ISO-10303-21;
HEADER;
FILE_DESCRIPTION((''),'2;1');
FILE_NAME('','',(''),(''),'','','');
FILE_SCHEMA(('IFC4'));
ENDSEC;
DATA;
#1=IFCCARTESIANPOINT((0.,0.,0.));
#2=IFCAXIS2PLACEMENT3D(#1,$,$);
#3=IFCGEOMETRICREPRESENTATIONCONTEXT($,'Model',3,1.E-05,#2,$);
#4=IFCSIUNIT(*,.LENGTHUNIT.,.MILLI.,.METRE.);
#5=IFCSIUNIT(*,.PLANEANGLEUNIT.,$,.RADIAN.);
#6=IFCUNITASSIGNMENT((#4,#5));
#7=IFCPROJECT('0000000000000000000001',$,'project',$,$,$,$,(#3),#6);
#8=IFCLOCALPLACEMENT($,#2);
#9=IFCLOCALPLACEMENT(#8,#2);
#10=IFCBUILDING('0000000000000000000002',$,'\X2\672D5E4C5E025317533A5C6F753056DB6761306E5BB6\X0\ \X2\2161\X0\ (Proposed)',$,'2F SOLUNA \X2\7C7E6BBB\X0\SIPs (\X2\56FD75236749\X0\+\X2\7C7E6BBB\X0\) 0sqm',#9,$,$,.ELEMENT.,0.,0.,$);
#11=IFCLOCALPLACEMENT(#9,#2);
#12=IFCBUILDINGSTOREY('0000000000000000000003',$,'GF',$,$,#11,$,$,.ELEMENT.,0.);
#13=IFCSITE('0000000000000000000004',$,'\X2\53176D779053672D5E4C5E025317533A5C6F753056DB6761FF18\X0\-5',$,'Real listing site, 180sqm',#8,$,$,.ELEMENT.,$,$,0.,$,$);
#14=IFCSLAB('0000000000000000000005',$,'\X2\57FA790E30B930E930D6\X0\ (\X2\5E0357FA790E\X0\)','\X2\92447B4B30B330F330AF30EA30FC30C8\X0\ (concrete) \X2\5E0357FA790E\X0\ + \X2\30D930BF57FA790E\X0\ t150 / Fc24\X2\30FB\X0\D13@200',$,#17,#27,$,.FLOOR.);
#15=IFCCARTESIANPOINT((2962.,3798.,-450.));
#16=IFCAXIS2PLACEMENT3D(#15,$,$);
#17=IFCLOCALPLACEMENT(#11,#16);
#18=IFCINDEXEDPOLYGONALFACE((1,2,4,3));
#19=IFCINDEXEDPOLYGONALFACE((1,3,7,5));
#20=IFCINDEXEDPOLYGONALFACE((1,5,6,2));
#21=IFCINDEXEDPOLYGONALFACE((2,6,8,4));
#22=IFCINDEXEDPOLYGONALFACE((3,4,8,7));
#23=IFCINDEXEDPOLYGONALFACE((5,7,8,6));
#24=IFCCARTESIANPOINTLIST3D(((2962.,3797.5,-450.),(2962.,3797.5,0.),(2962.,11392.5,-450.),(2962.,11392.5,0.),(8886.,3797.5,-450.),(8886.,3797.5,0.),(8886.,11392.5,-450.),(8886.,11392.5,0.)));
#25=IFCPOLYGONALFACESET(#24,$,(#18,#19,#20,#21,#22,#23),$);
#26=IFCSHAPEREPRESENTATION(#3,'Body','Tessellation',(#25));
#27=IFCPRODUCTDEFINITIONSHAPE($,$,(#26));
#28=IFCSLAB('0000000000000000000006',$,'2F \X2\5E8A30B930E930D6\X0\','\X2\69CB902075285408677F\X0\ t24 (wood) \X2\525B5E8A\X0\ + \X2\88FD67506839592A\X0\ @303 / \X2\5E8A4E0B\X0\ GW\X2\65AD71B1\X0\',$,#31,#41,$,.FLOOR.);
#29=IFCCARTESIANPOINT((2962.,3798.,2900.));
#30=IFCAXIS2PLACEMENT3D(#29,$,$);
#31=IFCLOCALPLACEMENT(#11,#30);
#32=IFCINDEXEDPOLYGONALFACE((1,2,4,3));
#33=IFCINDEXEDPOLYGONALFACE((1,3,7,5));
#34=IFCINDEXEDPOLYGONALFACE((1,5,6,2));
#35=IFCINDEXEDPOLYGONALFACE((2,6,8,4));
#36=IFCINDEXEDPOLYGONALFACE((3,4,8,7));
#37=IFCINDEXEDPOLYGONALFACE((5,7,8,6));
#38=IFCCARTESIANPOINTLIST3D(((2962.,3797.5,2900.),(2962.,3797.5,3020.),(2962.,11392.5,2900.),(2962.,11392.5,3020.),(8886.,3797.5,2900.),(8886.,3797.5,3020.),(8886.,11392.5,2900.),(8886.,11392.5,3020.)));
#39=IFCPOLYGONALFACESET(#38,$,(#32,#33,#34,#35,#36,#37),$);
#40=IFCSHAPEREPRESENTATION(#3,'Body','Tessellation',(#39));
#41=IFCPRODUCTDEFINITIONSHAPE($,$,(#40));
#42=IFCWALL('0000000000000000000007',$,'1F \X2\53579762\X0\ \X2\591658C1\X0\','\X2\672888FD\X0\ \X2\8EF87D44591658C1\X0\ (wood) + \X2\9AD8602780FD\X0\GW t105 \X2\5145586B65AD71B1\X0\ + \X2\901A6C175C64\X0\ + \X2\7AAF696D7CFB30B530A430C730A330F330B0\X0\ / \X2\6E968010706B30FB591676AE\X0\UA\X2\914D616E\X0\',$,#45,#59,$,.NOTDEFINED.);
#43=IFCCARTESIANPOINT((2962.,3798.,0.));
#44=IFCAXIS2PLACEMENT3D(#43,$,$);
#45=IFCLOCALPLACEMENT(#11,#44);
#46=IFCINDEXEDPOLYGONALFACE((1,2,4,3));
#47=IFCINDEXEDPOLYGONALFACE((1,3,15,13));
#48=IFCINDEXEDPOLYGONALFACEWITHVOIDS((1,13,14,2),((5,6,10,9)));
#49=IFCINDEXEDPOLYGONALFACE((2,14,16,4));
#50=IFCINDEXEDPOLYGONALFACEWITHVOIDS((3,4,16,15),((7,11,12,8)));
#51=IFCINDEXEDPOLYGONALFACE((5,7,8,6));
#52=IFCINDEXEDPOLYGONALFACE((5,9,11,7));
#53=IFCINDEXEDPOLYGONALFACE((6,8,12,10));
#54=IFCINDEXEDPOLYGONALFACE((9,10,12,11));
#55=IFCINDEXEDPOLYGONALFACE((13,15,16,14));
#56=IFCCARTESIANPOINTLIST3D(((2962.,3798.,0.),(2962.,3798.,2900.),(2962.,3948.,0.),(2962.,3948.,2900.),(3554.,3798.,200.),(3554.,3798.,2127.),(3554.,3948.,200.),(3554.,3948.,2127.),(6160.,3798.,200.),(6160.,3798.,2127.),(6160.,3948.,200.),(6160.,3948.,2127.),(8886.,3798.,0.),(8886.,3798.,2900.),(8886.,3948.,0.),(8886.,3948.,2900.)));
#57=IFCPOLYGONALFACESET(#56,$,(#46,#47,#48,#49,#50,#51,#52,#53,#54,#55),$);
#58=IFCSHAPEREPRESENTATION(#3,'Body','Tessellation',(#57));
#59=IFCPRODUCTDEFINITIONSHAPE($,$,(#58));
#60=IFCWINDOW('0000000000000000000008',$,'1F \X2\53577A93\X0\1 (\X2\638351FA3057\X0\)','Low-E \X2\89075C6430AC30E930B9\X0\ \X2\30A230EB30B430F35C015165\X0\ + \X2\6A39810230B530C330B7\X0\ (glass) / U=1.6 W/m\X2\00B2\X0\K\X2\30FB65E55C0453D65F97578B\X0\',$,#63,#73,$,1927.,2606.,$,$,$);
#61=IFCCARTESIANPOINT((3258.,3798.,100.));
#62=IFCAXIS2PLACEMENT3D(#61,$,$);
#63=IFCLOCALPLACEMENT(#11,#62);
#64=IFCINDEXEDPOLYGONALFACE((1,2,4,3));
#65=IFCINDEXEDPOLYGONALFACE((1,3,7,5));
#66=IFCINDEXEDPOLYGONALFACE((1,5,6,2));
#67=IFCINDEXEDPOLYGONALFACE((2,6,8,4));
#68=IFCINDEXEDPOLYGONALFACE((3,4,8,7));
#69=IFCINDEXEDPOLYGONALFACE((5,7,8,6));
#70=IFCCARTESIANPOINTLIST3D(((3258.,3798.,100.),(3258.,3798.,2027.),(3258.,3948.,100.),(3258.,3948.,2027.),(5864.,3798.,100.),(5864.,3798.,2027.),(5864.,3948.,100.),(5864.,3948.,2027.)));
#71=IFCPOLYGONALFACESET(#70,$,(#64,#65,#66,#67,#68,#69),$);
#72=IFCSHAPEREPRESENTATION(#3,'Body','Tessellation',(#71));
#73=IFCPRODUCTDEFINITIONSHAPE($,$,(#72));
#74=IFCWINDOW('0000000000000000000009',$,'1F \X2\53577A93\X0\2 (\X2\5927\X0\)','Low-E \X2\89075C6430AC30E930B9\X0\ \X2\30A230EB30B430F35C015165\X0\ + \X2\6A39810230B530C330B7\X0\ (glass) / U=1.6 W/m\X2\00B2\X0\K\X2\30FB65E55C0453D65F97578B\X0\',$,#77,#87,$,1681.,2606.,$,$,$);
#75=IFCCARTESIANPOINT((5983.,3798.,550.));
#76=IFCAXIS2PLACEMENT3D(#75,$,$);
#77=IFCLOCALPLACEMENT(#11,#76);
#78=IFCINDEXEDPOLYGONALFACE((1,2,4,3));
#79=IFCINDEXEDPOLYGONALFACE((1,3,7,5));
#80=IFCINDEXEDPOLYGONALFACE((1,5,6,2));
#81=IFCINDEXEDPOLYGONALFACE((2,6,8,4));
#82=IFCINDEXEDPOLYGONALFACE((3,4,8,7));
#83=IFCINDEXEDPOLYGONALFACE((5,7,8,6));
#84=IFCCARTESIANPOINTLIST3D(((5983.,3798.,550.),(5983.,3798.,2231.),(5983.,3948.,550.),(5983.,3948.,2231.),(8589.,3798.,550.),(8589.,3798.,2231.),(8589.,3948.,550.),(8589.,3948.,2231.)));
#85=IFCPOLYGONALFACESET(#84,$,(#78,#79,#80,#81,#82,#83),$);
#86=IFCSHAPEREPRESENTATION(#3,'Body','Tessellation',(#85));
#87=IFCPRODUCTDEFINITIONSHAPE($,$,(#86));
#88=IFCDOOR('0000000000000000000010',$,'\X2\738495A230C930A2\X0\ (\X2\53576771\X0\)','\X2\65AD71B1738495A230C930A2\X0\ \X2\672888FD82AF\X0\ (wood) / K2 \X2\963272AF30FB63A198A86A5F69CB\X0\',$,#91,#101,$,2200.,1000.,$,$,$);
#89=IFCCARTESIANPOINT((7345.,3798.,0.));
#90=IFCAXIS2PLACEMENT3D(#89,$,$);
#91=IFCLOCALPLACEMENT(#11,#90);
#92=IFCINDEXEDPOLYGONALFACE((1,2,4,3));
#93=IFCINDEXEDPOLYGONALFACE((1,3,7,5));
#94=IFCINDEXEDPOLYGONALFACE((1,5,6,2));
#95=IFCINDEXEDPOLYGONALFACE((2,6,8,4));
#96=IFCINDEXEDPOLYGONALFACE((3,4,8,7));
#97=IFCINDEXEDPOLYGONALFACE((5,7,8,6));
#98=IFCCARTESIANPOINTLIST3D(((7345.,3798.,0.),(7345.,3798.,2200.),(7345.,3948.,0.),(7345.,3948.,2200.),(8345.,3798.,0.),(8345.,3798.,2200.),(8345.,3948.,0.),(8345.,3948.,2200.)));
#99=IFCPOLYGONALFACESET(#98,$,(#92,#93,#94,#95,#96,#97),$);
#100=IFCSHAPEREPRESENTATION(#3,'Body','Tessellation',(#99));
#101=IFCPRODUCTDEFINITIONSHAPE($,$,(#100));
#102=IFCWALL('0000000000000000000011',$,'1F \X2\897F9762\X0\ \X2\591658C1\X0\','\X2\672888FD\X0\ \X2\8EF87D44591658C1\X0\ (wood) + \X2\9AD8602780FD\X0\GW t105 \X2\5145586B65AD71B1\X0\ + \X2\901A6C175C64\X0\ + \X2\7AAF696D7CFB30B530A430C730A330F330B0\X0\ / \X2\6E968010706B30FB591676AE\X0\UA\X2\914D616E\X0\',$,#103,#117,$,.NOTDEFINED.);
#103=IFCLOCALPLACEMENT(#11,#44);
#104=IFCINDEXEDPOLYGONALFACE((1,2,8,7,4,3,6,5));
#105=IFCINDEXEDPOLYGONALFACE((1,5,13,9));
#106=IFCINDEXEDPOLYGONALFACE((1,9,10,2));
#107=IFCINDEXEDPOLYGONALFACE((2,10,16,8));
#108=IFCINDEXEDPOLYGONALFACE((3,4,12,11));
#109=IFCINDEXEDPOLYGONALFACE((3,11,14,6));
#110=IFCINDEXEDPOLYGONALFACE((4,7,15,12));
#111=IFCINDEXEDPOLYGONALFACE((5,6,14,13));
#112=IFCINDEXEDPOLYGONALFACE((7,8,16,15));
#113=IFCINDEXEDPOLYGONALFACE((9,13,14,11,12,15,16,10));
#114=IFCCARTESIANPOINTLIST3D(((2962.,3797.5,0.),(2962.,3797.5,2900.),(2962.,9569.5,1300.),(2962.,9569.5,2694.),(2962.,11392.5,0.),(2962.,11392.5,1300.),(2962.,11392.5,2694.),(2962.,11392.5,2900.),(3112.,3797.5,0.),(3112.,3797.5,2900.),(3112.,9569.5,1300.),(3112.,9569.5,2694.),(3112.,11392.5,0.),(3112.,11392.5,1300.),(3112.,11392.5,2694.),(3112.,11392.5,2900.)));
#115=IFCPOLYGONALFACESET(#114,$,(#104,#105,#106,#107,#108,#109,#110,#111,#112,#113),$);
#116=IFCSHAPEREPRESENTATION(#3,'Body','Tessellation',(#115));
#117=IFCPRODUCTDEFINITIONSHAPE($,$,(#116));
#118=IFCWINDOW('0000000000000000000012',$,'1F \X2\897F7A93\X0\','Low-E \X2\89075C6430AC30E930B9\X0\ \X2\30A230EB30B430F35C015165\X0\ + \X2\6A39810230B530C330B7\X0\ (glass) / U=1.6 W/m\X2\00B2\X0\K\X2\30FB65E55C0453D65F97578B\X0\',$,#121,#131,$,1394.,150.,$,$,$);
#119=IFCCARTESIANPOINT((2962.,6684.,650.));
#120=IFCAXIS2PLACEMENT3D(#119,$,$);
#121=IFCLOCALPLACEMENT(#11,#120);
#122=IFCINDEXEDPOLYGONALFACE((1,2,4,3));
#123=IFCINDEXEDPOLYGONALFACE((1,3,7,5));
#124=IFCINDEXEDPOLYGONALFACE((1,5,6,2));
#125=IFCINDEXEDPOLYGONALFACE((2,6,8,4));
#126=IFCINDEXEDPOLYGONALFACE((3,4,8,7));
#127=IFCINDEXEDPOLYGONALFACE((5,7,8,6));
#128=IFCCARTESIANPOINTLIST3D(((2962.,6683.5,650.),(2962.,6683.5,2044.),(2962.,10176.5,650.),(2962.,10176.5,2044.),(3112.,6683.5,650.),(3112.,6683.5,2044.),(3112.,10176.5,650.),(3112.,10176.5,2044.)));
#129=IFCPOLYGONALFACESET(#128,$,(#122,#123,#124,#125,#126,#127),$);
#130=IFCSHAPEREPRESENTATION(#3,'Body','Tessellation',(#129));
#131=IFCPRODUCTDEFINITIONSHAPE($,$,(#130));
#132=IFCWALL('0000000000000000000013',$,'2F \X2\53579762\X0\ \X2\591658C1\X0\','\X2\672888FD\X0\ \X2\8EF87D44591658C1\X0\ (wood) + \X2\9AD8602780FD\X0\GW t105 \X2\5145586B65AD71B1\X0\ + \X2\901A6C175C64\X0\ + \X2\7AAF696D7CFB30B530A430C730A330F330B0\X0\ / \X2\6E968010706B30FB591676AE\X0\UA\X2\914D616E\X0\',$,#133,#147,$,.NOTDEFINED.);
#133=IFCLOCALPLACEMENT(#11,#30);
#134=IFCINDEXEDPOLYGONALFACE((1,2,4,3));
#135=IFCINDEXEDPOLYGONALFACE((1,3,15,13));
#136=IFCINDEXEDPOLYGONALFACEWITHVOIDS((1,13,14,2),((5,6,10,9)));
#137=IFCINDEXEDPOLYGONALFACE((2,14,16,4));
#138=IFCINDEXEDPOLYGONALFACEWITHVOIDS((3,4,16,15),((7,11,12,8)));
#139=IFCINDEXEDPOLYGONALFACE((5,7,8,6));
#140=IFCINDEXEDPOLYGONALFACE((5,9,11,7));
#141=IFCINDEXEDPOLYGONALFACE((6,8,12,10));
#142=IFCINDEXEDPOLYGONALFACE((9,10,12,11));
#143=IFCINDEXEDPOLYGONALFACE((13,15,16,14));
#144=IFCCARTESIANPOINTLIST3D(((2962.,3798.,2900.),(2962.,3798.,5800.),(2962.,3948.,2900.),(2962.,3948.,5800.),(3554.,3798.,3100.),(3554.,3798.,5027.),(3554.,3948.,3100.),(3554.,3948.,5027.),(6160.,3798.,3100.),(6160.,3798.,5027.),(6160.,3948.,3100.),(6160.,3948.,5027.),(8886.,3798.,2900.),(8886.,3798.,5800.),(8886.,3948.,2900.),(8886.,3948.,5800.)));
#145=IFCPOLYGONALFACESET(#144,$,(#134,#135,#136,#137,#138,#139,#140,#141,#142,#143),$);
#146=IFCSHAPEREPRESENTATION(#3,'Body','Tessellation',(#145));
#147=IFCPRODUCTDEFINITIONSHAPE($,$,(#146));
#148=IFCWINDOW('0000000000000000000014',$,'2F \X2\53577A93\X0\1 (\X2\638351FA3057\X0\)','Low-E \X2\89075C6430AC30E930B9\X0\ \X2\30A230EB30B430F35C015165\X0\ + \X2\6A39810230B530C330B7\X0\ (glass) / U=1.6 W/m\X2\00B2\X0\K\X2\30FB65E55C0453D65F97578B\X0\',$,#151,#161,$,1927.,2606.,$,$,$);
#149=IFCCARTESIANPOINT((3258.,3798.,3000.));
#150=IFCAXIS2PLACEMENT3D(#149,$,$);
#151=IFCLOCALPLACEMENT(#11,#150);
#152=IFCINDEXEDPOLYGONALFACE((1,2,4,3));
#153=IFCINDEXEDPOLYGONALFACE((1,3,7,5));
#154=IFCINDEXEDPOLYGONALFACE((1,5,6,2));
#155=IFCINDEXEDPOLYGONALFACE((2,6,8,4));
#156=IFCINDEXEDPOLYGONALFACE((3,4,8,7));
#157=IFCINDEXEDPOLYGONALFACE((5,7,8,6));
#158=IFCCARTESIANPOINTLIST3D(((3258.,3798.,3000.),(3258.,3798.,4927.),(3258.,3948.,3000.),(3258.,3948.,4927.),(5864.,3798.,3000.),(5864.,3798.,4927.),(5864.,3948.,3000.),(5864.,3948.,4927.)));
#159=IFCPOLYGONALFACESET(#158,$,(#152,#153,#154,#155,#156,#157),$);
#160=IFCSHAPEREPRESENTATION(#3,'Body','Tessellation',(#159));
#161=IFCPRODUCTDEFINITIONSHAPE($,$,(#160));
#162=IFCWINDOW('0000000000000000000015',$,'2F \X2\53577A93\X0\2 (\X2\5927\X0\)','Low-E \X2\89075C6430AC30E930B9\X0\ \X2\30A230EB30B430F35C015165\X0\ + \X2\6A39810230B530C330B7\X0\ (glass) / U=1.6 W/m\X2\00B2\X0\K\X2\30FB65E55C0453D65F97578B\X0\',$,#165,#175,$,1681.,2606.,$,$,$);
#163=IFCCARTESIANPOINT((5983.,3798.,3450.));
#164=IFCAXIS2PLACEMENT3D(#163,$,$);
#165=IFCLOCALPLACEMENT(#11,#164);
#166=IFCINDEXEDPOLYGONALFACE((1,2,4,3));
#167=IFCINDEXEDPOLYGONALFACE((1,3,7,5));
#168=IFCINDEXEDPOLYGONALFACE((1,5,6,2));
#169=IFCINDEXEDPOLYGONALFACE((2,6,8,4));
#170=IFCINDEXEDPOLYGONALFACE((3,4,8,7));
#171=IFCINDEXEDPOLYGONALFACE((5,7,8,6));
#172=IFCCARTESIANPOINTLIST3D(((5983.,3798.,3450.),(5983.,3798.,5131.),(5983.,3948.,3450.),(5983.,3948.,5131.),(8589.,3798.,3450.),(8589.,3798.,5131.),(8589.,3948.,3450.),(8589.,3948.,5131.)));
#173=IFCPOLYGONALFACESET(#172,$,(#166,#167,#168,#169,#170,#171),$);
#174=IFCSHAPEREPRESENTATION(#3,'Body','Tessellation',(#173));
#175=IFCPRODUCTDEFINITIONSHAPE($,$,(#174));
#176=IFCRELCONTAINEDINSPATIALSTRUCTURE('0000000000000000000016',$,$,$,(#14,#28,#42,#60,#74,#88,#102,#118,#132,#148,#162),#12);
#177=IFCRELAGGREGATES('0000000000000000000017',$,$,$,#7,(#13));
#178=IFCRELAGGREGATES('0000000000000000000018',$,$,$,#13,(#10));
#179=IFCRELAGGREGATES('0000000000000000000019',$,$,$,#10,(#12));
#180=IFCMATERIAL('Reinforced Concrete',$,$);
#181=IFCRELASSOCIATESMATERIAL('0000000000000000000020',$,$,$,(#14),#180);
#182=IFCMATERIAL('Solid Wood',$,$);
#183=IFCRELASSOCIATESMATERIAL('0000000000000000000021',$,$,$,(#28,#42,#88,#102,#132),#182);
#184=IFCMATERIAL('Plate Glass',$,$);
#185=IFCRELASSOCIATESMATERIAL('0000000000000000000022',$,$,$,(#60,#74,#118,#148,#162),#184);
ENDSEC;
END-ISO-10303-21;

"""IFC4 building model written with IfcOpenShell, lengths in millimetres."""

from ifc_helpers import new_model, si_unit, frame, frame_2d, origin, place, context, project, spatial, rectangle, extrude, material, element, fill, save


model = new_model("IFC4")

# Units and contexts
model_context = context("Model", 3, precision=1e-05, world=origin())
ifc_project = project(units=[si_unit("LENGTHUNIT", "METRE", prefix="MILLI"), si_unit("PLANEANGLEUNIT", "RADIAN")], contexts=[model_context])

# Site, building, storey
site_placement = place(None, origin())
site = spatial("IfcSite", under=ifc_project, at=site_placement, Name="北海道札幌市北区屯田四条８-5", ObjectType="Real listing site, 180sqm", CompositionType="ELEMENT", RefElevation=0.0)
building_placement = place(site_placement, origin())
building = spatial("IfcBuilding", under=site, at=building_placement, Name="札幌市北区屯田四条の家 Ⅱ (Proposed)", ObjectType="2F SOLUNA 籾殻SIPs (国産杉+籾殻) 0sqm", CompositionType="ELEMENT", ElevationOfRefHeight=0.0, ElevationOfTerrain=0.0)
storey_placement = place(building_placement, origin())
storey = spatial("IfcBuildingStorey", under=building, at=storey_placement, Name="GF", CompositionType="ELEMENT", Elevation=0.0)

# Slabs
ifc_material_1 = material(Name="Reinforced Concrete")
slab_1_placement = place(storey_placement, frame((2962.0, 3798.0, -450.0)))
element("IfcSlab", 1, at=slab_1_placement, inside=storey, material=ifc_material_1, Name="基礎スラブ (布基礎)", Description="鉄筋コンクリート (concrete) 布基礎 + ベタ基礎 t150 / Fc24・D13@200", PredefinedType="FLOOR", context=model_context, shape_type="SweptSolid", body=[
    extrude(rectangle(XDim=5924.0, YDim=7595.0, at=frame_2d((2962.0, 3797.0))), frame((2962.0, 3798.0, -450.0)), (0.0, 0.0, 1.0), 450.0),
])
ifc_material_2 = material(Name="Solid Wood")
slab_2_placement = place(storey_placement, frame((2962.0, 3798.0, 2900.0)))
element("IfcSlab", 2, at=slab_2_placement, inside=storey, material=ifc_material_2, Name="2F 床スラブ", Description="構造用合板 t24 (wood) 剛床 + 製材根太 @303 / 床下 GW断熱", PredefinedType="FLOOR", context=model_context, shape_type="SweptSolid", body=[
    extrude(rectangle(XDim=5924.0, YDim=7595.0, at=frame_2d((2962.0, 3797.0))), frame((2962.0, 3798.0, 2900.0)), (0.0, 0.0, 1.0), 120.0),
])

# Wall, openings, windows, door
wall_1_placement = place(storey_placement, frame((2962.0, 3798.0, 0.0)))
wall_1 = element("IfcWall", 3, at=wall_1_placement, inside=storey, material=ifc_material_2, Name="1F 南面 外壁", Description="木製 軸組外壁 (wood) + 高性能GW t105 充填断熱 + 通気層 + 窯業系サイディング / 準耐火・外皮UA配慮", PredefinedType="NOTDEFINED", context=model_context, shape_type="SweptSolid", body=[
    extrude(rectangle(XDim=5924.0, YDim=150.0, at=frame_2d((2962.0, 75.0))), frame((2962.0, 3798.0, 0.0)), (0.0, 0.0, 1.0), 2900.0),
])
opening_1_placement = place(storey_placement, frame((3258.0, 3798.0, 100.0)))
opening_1 = element("IfcOpeningElement", 4, at=opening_1_placement, cuts=wall_1, PredefinedType="NOTDEFINED", context=model_context, shape_type="SweptSolid", body=[
    extrude(rectangle(XDim=2606.0, YDim=150.0, at=frame_2d((1303.0, 75.0))), frame((3258.0, 3798.0, 100.0)), (0.0, 0.0, 1.0), 1927.0),
])
opening_2_placement = place(storey_placement, frame((5983.0, 3798.0, 550.0)))
opening_2 = element("IfcOpeningElement", 5, at=opening_2_placement, cuts=wall_1, PredefinedType="NOTDEFINED", context=model_context, shape_type="SweptSolid", body=[
    extrude(rectangle(XDim=2606.0, YDim=150.0, at=frame_2d((1303.0, 75.0))), frame((5983.0, 3798.0, 550.0)), (0.0, 0.0, 1.0), 1681.0),
])
opening_3_placement = place(storey_placement, frame((7345.0, 3798.0, 0.0)))
opening_3 = element("IfcOpeningElement", 6, at=opening_3_placement, cuts=wall_1, PredefinedType="NOTDEFINED", context=model_context, shape_type="SweptSolid", body=[
    extrude(rectangle(XDim=1000.0, YDim=150.0, at=frame_2d((500.0, 75.0))), frame((7345.0, 3798.0, 0.0)), (0.0, 0.0, 1.0), 2200.0),
])
ifc_material_3 = material(Name="Plate Glass")
window_1_placement = place(storey_placement, frame((3258.0, 3798.0, 100.0)))
window_1 = element("IfcWindow", 7, at=window_1_placement, inside=storey, material=ifc_material_3, Name="1F 南窓1 (掃出し)", Description="Low-E 複層ガラス アルゴン封入 + 樹脂サッシ (glass) / U=1.6 W/m²K・日射取得型", OverallHeight=1927.0, OverallWidth=2606.0, context=model_context, shape_type="SweptSolid", body=[
    extrude(rectangle(XDim=2606.0, YDim=150.0, at=frame_2d((1303.0, 75.0))), frame((3258.0, 3798.0, 100.0)), (0.0, 0.0, 1.0), 1927.0),
])
fill(opening_1, window_1)
window_2_placement = place(storey_placement, frame((5983.0, 3798.0, 550.0)))
window_2 = element("IfcWindow", 8, at=window_2_placement, inside=storey, material=ifc_material_3, Name="1F 南窓2 (大)", Description="Low-E 複層ガラス アルゴン封入 + 樹脂サッシ (glass) / U=1.6 W/m²K・日射取得型", OverallHeight=1681.0, OverallWidth=2606.0, context=model_context, shape_type="SweptSolid", body=[
    extrude(rectangle(XDim=2606.0, YDim=150.0, at=frame_2d((1303.0, 75.0))), frame((5983.0, 3798.0, 550.0)), (0.0, 0.0, 1.0), 1681.0),
])
fill(opening_2, window_2)
door_placement = place(storey_placement, frame((7345.0, 3798.0, 0.0)))
door = element("IfcDoor", 9, at=door_placement, inside=storey, material=ifc_material_2, Name="玄関ドア (南東)", Description="断熱玄関ドア 木製芯 (wood) / K2 防犯・採風機構", OverallHeight=2200.0, OverallWidth=1000.0, context=model_context, shape_type="SweptSolid", body=[
    extrude(rectangle(XDim=1000.0, YDim=150.0, at=frame_2d((500.0, 75.0))), frame((7345.0, 3798.0, 0.0)), (0.0, 0.0, 1.0), 2200.0),
])
fill(opening_3, door)

# Wall, opening, window
wall_2_placement = place(storey_placement, frame((2962.0, 3798.0, 0.0)))
wall_2 = element("IfcWall", 10, at=wall_2_placement, inside=storey, material=ifc_material_2, Name="1F 西面 外壁", Description="木製 軸組外壁 (wood) + 高性能GW t105 充填断熱 + 通気層 + 窯業系サイディング / 準耐火・外皮UA配慮", PredefinedType="NOTDEFINED", context=model_context, shape_type="SweptSolid", body=[
    extrude(rectangle(XDim=150.0, YDim=7595.0, at=frame_2d((75.0, 3797.0))), frame((2962.0, 3798.0, 0.0)), (0.0, 0.0, 1.0), 2900.0),
])
opening_4_placement = place(storey_placement, frame((2962.0, 6684.0, 650.0)))
opening_4 = element("IfcOpeningElement", 11, at=opening_4_placement, cuts=wall_2, PredefinedType="NOTDEFINED", context=model_context, shape_type="SweptSolid", body=[
    extrude(rectangle(XDim=150.0, YDim=3493.0, at=frame_2d((75.0, 1746.0))), frame((2962.0, 6684.0, 650.0)), (0.0, 0.0, 1.0), 1394.0),
])
window_3_placement = place(storey_placement, frame((2962.0, 6684.0, 650.0)))
window_3 = element("IfcWindow", 12, at=window_3_placement, inside=storey, material=ifc_material_3, Name="1F 西窓", Description="Low-E 複層ガラス アルゴン封入 + 樹脂サッシ (glass) / U=1.6 W/m²K・日射取得型", OverallHeight=1394.0, OverallWidth=150.0, context=model_context, shape_type="SweptSolid", body=[
    extrude(rectangle(XDim=150.0, YDim=3493.0, at=frame_2d((75.0, 1746.0))), frame((2962.0, 6684.0, 650.0)), (0.0, 0.0, 1.0), 1394.0),
])
fill(opening_4, window_3)

# Wall, openings, windows
wall_3_placement = place(storey_placement, frame((2962.0, 3798.0, 2900.0)))
wall_3 = element("IfcWall", 13, at=wall_3_placement, inside=storey, material=ifc_material_2, Name="2F 南面 外壁", Description="木製 軸組外壁 (wood) + 高性能GW t105 充填断熱 + 通気層 + 窯業系サイディング / 準耐火・外皮UA配慮", PredefinedType="NOTDEFINED", context=model_context, shape_type="SweptSolid", body=[
    extrude(rectangle(XDim=5924.0, YDim=150.0, at=frame_2d((2962.0, 75.0))), frame((2962.0, 3798.0, 2900.0)), (0.0, 0.0, 1.0), 2900.0),
])
opening_5_placement = place(storey_placement, frame((3258.0, 3798.0, 3000.0)))
opening_5 = element("IfcOpeningElement", 14, at=opening_5_placement, cuts=wall_3, PredefinedType="NOTDEFINED", context=model_context, shape_type="SweptSolid", body=[
    extrude(rectangle(XDim=2606.0, YDim=150.0, at=frame_2d((1303.0, 75.0))), frame((3258.0, 3798.0, 3000.0)), (0.0, 0.0, 1.0), 1927.0),
])
opening_6_placement = place(storey_placement, frame((5983.0, 3798.0, 3450.0)))
opening_6 = element("IfcOpeningElement", 15, at=opening_6_placement, cuts=wall_3, PredefinedType="NOTDEFINED", context=model_context, shape_type="SweptSolid", body=[
    extrude(rectangle(XDim=2606.0, YDim=150.0, at=frame_2d((1303.0, 75.0))), frame((5983.0, 3798.0, 3450.0)), (0.0, 0.0, 1.0), 1681.0),
])
window_4_placement = place(storey_placement, frame((3258.0, 3798.0, 3000.0)))
window_4 = element("IfcWindow", 16, at=window_4_placement, inside=storey, material=ifc_material_3, Name="2F 南窓1 (掃出し)", Description="Low-E 複層ガラス アルゴン封入 + 樹脂サッシ (glass) / U=1.6 W/m²K・日射取得型", OverallHeight=1927.0, OverallWidth=2606.0, context=model_context, shape_type="SweptSolid", body=[
    extrude(rectangle(XDim=2606.0, YDim=150.0, at=frame_2d((1303.0, 75.0))), frame((3258.0, 3798.0, 3000.0)), (0.0, 0.0, 1.0), 1927.0),
])
fill(opening_5, window_4)
window_5_placement = place(storey_placement, frame((5983.0, 3798.0, 3450.0)))
window_5 = element("IfcWindow", 17, at=window_5_placement, inside=storey, material=ifc_material_3, Name="2F 南窓2 (大)", Description="Low-E 複層ガラス アルゴン封入 + 樹脂サッシ (glass) / U=1.6 W/m²K・日射取得型", OverallHeight=1681.0, OverallWidth=2606.0, context=model_context, shape_type="SweptSolid", body=[
    extrude(rectangle(XDim=2606.0, YDim=150.0, at=frame_2d((1303.0, 75.0))), frame((5983.0, 3798.0, 3450.0)), (0.0, 0.0, 1.0), 1681.0),
])
fill(opening_6, window_5)

save(model, "model.ifc")
